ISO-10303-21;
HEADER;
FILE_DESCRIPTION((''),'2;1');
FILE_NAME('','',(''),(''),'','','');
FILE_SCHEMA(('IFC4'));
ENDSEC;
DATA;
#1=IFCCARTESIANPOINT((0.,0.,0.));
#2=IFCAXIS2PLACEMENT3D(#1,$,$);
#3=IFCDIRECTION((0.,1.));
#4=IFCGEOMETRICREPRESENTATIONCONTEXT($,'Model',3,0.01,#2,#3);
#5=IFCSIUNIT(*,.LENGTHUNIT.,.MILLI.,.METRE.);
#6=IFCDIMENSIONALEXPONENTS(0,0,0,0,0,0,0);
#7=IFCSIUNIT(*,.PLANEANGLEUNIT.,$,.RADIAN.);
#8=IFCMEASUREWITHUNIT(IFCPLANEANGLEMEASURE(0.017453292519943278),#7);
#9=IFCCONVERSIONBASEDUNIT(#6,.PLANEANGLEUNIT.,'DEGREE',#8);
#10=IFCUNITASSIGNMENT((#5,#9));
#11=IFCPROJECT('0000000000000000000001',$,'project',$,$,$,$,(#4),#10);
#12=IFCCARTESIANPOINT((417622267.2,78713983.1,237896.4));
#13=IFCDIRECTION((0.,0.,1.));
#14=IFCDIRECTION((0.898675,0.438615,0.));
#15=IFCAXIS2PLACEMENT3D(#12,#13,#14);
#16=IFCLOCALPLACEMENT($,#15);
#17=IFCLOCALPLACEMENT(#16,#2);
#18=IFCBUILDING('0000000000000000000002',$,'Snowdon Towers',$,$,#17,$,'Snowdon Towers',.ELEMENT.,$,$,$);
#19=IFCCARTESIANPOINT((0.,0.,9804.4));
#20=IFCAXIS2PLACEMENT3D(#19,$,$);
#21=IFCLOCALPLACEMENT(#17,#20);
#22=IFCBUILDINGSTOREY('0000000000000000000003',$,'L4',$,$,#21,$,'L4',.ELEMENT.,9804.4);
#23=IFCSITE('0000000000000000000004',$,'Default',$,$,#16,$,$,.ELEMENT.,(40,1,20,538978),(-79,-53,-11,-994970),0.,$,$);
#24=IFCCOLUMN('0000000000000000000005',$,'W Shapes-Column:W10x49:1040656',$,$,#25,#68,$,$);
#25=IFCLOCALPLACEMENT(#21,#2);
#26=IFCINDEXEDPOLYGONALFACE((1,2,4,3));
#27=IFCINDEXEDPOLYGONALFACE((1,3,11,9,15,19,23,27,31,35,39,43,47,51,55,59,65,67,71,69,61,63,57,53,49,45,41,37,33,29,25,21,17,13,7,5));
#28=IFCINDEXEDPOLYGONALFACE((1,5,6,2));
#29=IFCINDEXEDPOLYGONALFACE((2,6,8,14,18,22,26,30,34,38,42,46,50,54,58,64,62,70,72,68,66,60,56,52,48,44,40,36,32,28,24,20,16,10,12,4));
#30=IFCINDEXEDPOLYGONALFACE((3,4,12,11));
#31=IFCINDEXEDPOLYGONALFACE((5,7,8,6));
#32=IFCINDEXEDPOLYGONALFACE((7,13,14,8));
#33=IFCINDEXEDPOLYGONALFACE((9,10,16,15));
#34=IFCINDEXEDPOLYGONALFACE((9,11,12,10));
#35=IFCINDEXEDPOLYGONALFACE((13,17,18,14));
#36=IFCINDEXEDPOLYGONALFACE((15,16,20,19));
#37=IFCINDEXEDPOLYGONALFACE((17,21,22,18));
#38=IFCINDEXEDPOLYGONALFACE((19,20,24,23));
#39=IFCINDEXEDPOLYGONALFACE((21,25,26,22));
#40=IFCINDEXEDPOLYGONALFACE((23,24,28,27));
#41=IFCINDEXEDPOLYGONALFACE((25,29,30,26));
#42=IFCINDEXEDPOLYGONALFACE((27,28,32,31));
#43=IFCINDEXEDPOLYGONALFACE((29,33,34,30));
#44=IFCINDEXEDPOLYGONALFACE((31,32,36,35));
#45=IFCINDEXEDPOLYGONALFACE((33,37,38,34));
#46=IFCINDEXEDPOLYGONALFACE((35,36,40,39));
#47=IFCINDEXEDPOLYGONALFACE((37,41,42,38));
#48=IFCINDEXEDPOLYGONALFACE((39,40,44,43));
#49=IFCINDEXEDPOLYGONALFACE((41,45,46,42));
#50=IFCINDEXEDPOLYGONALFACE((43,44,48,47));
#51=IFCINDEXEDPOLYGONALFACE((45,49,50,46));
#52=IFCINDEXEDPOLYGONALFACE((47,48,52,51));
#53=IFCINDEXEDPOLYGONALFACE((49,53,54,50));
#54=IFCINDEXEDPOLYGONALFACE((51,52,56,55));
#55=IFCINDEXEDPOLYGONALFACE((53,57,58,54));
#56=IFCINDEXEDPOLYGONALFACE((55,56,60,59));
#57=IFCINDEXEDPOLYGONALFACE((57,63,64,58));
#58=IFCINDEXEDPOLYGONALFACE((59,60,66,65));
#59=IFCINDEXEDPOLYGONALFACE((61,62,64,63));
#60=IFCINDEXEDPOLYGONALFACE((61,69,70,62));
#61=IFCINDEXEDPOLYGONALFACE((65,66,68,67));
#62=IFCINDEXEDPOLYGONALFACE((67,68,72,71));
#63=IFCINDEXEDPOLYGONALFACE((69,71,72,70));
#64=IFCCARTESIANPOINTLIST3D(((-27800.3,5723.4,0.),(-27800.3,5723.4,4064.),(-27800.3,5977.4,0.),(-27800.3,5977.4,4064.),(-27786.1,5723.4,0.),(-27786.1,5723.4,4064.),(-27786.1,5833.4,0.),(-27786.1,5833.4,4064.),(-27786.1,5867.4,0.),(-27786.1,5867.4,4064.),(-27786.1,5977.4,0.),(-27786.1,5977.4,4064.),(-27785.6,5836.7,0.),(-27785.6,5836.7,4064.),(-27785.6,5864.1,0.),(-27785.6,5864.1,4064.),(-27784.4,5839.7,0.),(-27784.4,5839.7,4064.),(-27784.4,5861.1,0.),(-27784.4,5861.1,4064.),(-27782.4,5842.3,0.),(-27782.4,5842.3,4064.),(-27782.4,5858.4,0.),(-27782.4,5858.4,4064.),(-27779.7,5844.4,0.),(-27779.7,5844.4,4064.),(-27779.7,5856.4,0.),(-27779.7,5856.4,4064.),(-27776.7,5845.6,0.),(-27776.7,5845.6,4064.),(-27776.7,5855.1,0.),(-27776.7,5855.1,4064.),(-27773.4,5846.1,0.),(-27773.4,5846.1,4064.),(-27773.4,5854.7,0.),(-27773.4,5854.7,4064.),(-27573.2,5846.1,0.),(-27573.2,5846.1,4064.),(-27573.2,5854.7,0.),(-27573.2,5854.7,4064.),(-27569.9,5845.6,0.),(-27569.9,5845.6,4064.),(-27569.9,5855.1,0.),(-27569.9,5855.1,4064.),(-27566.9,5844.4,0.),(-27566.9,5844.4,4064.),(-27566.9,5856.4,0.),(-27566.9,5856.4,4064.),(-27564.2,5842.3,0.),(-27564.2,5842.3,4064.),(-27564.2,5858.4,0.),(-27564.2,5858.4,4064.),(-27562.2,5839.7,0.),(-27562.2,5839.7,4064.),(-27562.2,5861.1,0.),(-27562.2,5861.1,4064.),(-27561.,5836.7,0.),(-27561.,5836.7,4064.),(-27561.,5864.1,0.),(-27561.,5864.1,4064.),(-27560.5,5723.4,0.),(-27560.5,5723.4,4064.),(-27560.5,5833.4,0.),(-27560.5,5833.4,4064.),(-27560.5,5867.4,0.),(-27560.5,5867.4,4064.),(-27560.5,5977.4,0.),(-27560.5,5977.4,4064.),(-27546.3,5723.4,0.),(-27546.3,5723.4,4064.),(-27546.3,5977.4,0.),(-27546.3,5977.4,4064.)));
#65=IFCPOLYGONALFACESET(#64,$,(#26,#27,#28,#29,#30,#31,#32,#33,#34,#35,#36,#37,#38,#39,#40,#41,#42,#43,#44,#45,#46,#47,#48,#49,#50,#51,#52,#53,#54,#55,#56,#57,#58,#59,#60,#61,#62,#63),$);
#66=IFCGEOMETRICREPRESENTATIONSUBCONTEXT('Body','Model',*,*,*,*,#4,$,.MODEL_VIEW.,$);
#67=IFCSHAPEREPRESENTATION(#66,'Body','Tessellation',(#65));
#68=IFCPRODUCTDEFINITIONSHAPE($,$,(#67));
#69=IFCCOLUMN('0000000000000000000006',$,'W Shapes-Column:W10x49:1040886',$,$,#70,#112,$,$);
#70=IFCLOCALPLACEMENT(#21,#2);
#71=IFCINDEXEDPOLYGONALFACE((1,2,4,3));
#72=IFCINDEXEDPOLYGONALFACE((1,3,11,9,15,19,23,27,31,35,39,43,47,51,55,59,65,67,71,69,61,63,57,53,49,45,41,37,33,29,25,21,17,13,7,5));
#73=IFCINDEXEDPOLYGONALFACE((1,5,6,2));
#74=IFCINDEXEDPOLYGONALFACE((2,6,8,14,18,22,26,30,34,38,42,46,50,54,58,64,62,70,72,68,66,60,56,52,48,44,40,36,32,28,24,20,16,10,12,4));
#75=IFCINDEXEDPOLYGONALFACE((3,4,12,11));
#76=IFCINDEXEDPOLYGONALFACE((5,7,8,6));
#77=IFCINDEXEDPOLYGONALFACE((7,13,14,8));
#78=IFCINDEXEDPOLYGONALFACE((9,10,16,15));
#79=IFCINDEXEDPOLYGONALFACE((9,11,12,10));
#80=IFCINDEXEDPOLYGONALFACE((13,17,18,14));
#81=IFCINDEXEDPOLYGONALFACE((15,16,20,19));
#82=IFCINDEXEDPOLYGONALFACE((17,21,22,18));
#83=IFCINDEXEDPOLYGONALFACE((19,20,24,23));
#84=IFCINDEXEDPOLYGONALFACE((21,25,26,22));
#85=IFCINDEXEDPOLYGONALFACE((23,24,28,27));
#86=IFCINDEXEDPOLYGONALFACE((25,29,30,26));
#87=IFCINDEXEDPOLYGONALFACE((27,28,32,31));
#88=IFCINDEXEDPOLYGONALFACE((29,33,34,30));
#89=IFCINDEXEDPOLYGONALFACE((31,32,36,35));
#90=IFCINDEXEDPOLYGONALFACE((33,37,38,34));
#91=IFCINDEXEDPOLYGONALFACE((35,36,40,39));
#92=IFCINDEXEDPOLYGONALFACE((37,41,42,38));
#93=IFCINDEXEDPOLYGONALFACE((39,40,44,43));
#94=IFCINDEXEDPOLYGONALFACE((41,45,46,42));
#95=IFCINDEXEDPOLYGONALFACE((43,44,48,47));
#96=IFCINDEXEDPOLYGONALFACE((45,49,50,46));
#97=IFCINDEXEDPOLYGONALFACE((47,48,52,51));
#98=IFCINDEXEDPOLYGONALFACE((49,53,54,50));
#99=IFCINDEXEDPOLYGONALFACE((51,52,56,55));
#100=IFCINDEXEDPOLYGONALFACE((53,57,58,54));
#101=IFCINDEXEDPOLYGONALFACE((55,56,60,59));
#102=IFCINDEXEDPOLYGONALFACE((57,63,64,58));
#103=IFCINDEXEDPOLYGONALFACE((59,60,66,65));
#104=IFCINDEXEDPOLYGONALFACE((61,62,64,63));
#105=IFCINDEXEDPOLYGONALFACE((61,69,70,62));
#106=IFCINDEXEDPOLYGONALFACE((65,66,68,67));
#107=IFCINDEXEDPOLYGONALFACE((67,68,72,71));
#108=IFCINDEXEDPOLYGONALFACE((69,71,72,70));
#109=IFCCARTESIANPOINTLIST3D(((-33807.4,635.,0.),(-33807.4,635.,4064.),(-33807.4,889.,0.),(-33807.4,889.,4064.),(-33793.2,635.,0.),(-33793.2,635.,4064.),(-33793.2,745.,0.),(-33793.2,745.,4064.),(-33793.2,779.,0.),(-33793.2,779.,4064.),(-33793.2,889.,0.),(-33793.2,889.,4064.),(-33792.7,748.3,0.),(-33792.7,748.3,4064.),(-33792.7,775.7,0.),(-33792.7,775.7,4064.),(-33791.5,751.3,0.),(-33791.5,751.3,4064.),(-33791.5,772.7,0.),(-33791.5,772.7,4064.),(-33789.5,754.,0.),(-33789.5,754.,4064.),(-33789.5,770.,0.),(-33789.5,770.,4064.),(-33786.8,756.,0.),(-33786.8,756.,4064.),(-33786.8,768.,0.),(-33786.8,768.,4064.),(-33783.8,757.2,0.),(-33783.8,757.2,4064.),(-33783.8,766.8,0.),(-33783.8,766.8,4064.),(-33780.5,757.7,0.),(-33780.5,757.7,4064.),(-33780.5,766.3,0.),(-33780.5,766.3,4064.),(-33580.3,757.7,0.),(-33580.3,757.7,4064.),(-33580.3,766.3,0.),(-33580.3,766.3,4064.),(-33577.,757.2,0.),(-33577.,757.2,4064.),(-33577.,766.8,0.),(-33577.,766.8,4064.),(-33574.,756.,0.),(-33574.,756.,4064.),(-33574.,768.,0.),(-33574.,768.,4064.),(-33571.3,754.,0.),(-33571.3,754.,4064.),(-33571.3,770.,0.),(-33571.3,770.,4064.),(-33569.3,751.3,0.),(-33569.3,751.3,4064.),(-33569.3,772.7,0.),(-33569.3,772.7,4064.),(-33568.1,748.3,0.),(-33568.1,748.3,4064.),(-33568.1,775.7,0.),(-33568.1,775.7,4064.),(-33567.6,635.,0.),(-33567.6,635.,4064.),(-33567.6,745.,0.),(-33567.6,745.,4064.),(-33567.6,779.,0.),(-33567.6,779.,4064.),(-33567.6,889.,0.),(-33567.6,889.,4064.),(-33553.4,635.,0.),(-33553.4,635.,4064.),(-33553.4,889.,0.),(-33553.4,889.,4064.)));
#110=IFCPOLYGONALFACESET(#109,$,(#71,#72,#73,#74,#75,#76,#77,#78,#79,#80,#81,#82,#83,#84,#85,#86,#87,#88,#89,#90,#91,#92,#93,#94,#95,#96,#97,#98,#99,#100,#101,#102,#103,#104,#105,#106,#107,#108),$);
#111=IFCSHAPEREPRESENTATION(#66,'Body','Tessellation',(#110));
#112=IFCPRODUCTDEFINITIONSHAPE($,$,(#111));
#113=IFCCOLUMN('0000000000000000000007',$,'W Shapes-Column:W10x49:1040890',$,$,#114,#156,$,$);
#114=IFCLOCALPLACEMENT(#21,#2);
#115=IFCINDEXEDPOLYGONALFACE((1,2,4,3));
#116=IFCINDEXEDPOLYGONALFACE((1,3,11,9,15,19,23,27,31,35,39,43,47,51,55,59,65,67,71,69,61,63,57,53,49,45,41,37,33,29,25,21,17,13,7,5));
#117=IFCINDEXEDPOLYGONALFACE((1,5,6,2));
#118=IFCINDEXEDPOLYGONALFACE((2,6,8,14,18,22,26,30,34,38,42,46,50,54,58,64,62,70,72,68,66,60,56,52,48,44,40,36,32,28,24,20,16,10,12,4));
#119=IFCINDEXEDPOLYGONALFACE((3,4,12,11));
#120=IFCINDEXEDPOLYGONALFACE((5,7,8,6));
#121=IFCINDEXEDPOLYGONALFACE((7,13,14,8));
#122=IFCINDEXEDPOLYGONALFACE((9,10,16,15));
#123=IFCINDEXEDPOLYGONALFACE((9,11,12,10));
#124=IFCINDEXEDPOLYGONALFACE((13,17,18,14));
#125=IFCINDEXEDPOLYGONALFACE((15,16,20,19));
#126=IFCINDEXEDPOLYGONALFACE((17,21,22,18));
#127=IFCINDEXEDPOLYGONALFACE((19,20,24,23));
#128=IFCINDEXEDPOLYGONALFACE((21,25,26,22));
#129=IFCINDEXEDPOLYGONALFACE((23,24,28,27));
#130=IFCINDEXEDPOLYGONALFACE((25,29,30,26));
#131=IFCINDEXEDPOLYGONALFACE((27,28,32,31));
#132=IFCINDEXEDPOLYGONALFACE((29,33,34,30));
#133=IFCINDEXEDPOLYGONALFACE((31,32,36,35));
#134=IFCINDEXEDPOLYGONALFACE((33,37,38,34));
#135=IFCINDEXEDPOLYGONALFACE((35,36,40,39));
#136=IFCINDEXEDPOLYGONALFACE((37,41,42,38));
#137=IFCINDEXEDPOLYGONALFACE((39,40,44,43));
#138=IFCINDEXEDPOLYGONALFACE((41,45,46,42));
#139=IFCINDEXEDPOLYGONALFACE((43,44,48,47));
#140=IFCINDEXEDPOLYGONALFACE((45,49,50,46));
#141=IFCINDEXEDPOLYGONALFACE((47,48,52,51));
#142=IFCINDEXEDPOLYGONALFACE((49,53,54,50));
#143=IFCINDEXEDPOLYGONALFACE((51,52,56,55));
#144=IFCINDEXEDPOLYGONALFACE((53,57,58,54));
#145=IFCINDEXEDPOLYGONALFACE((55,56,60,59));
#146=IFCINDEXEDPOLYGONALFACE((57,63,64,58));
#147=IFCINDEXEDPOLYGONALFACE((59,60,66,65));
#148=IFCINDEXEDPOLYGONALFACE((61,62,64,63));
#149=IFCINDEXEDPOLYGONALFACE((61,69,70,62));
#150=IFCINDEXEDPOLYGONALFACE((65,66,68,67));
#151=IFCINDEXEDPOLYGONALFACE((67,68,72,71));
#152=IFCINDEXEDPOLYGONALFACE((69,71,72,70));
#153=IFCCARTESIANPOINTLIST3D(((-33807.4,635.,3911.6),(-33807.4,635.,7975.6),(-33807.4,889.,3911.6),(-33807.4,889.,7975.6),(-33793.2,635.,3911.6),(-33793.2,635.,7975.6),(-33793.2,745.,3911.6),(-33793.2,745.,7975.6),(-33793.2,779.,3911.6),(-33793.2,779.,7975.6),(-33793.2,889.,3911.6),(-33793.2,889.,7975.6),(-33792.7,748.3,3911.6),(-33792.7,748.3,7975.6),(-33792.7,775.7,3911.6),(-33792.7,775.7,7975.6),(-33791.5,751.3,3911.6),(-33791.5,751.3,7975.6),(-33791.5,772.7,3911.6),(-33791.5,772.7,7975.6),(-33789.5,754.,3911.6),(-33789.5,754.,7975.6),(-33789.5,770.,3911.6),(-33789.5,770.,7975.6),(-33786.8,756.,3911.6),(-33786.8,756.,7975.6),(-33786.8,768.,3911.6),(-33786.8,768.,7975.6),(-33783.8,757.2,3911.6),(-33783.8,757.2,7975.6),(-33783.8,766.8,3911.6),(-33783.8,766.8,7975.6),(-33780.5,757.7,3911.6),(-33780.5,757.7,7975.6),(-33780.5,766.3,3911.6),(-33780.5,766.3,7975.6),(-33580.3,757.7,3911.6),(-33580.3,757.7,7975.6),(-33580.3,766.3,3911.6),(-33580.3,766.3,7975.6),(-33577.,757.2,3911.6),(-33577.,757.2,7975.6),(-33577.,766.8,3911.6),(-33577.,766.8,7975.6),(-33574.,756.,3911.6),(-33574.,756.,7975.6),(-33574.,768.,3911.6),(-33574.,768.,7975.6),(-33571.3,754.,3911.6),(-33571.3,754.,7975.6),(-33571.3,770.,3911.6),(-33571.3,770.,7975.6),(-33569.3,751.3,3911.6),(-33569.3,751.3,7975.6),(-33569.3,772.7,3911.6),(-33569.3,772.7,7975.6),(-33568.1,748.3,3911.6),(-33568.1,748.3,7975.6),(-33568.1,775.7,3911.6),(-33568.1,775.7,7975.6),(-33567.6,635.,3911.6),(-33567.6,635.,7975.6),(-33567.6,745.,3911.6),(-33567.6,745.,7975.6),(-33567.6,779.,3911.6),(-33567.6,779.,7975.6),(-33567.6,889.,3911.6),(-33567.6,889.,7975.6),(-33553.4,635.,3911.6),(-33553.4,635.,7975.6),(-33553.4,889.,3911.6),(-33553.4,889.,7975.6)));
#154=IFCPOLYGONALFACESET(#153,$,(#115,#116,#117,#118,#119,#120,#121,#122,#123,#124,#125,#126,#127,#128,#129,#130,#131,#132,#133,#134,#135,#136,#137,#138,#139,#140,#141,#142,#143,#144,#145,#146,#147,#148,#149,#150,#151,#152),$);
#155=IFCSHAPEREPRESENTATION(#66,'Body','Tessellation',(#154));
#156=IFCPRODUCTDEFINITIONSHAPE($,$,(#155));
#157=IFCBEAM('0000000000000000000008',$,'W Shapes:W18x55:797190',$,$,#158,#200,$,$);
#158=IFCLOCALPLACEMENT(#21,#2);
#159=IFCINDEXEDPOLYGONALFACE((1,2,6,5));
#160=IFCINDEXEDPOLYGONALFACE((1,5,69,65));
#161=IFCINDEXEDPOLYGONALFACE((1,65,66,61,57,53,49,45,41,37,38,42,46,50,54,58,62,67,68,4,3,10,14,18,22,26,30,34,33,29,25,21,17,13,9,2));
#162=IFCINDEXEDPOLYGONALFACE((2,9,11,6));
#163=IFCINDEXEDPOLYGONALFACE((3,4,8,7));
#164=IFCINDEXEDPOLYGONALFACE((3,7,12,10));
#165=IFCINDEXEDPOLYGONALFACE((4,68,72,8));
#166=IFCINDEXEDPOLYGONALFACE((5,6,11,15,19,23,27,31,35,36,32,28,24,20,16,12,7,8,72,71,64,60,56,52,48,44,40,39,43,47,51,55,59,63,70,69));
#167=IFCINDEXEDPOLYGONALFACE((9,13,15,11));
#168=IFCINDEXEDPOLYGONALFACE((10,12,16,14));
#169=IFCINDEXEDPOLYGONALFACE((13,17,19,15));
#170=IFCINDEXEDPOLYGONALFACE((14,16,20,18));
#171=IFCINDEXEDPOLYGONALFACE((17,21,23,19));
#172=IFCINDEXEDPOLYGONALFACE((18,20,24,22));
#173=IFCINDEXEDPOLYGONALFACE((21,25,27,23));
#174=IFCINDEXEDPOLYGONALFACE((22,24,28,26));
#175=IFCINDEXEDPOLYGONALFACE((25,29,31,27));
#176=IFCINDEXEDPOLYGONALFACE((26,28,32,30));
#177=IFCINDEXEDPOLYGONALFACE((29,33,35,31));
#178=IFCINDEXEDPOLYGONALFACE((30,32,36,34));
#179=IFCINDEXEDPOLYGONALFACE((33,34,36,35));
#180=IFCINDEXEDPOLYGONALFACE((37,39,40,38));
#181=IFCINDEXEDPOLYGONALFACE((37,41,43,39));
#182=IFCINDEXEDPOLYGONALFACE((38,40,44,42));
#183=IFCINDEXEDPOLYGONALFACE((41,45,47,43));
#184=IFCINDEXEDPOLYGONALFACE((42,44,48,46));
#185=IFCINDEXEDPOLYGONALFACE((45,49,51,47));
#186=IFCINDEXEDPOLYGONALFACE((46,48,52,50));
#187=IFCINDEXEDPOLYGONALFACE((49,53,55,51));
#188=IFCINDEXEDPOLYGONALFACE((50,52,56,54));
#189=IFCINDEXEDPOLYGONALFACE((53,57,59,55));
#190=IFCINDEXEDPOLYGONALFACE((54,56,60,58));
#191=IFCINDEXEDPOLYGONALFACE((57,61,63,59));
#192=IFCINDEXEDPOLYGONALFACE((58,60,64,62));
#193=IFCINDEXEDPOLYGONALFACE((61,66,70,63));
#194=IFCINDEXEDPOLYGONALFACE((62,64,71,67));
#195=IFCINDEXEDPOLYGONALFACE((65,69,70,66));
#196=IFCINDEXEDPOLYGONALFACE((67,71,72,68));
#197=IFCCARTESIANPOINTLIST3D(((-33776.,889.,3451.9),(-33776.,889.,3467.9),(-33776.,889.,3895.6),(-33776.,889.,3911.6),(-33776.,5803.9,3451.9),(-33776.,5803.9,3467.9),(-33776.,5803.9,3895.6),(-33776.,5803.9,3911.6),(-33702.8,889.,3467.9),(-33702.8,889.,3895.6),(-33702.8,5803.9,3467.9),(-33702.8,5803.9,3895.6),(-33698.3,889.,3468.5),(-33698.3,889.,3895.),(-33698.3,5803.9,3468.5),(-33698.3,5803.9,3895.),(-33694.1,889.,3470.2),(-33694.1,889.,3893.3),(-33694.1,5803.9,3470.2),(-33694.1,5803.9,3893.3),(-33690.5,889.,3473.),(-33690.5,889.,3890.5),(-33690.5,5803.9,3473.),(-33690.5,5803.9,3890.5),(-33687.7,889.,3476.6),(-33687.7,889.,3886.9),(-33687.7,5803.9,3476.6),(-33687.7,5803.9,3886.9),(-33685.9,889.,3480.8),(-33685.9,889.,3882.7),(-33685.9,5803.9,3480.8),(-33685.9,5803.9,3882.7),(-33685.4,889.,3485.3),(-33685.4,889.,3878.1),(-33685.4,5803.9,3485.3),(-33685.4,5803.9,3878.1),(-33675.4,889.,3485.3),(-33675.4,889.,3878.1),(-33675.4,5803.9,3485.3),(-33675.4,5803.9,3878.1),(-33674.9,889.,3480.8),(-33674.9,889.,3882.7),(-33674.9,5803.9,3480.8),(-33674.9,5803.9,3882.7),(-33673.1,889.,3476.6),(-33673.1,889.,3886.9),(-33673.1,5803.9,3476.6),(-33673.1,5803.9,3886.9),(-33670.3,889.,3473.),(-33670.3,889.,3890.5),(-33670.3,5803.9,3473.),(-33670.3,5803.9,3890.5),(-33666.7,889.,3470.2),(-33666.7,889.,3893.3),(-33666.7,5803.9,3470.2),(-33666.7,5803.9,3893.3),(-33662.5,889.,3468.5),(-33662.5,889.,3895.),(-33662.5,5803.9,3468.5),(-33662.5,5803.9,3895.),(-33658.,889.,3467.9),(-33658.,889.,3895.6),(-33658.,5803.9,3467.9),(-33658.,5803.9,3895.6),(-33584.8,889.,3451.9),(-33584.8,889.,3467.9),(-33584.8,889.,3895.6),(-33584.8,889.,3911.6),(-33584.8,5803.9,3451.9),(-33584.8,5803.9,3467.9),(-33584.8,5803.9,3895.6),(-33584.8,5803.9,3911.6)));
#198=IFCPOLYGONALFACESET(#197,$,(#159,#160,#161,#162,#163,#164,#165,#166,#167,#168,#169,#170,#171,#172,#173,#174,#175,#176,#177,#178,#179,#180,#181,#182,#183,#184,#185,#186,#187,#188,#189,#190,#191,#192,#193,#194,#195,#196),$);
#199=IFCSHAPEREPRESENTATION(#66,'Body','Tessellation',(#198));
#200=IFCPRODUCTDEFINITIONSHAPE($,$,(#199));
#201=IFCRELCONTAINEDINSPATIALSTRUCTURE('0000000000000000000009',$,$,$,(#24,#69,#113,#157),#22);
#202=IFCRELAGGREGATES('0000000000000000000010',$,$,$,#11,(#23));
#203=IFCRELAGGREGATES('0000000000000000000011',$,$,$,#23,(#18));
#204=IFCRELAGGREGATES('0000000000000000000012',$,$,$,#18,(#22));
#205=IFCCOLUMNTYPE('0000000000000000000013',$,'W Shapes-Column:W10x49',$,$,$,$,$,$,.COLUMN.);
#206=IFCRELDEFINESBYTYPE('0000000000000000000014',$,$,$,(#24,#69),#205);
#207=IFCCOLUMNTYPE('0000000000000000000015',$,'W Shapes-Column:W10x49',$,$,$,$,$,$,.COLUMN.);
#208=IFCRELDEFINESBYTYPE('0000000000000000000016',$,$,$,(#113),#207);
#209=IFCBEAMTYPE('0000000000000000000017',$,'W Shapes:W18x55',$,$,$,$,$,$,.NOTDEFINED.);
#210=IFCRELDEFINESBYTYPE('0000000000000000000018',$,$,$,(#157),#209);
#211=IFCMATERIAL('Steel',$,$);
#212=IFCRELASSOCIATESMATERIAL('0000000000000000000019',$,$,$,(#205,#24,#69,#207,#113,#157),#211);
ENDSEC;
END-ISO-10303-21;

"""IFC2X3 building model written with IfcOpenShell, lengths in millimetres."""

from ifc_helpers import new_model, entity, si_unit, converted_unit, direction, frame, frame_2d, origin, place, context, subcontext, project, spatial, i_section, extrude, source, transform, mapped, material, type_object, type_shapes, element, save


model = new_model("IFC2X3")

# Units and contexts
model_context = context("Model", 3, precision=0.01, world=origin(), true_north=direction((0.0, 1.0)))
body_context = subcontext(model_context, "Body", "Model", "MODEL_VIEW")
ifc_project = project(units=[si_unit("LENGTHUNIT", "METRE", prefix="MILLI"), converted_unit("PLANEANGLEUNIT", "DEGREE", entity("IfcPlaneAngleMeasure", 0.017453292519943278), si_unit("PLANEANGLEUNIT", "RADIAN"), dimensions=[0, 0, 0, 0, 0, 0, 0])], contexts=[model_context])

# Site, building, storey
site_placement = place(None, frame((417622267.2, 78713983.1, 237896.4), z_axis=(0.0, 0.0, 1.0), x_axis=(0.898675, 0.438615, 0.0)))
site = spatial("IfcSite", under=ifc_project, at=site_placement, Name="Default", CompositionType="ELEMENT", RefLatitude=(40, 1, 20, 538978), RefLongitude=(-79, -53, -11, -994970), RefElevation=0.0)
building_placement = place(site_placement, origin())
building = spatial("IfcBuilding", under=site, at=building_placement, Name="Snowdon Towers", LongName="Snowdon Towers", CompositionType="ELEMENT")
storey_placement = place(building_placement, frame((0.0, 0.0, 9804.4)))
storey = spatial("IfcBuildingStorey", under=building, at=storey_placement, Name="L4", LongName="L4", CompositionType="ELEMENT", Elevation=9804.4)

# Columns
ifc_material_1 = material(Name="Steel")
column_type_1 = type_object("IfcColumnType", Name="W Shapes-Column:W10x49", PredefinedType="COLUMN", material=ifc_material_1)
shared_shape_1 = source(origin(), body_context, "Body", "SweptSolid", [
    extrude(i_section(OverallWidth=254.0, OverallDepth=254.0, WebThickness=8.6, FlangeThickness=14.2, FilletRadius=12.7, at=frame_2d((0.0, 0.0), x_axis=(1.0, 0.0))), frame((0.0, 0.0, 9804.4), z_axis=(0.0, 0.0, 1.0), x_axis=(-1.0, 0.0, 0.0)), (0.0, 0.0, 1.0), 4064.0),
])
type_shapes(column_type_1, [shared_shape_1])
for number, where, z_axis, x_axis, name in (
    (1, (-27673.3, 5850.4, -9804.4), (0.0, 0.0, 1.0), (0.0, 1.0, 0.0), "W Shapes-Column:W10x49:1040656"),
    (2, (-33680.4, 762.0, -9804.4), (0.0, 0.0, 1.0), (0.0, 1.0, 0.0), "W Shapes-Column:W10x49:1040886"),
):
    element("IfcColumn", number, at=place(storey_placement, frame(where, z_axis=z_axis, x_axis=x_axis)), inside=storey, type_object=column_type_1, material=ifc_material_1, Name=name, context=body_context, shape_type="MappedRepresentation", body=[
        mapped(shared_shape_1, transform((0.0, 0.0, 0.0), scale=1.0)),
    ])
column_type_2 = type_object("IfcColumnType", Name="W Shapes-Column:W10x49", PredefinedType="COLUMN", material=ifc_material_1)
shared_shape_2 = source(origin(), body_context, "Body", "SweptSolid", [
    extrude(i_section(OverallWidth=254.0, OverallDepth=254.0, WebThickness=8.6, FlangeThickness=14.2, FilletRadius=12.7, at=frame_2d((0.0, 0.0), x_axis=(1.0, 0.0))), frame((0.0, 0.0, 13716.0), z_axis=(0.0, 0.0, 1.0), x_axis=(-1.0, 0.0, 0.0)), (0.0, 0.0, 1.0), 4064.0),
])
type_shapes(column_type_2, [shared_shape_2])
column_placement = place(storey_placement, frame((-33680.4, 762.0, -9804.4), z_axis=(0.0, 0.0, 1.0), x_axis=(0.0, 1.0, 0.0)))
element("IfcColumn", 3, at=column_placement, inside=storey, type_object=column_type_2, material=ifc_material_1, Name="W Shapes-Column:W10x49:1040890", context=body_context, shape_type="MappedRepresentation", body=[
    mapped(shared_shape_2, transform((0.0, 0.0, 0.0), scale=1.0)),
])

# Beam
beam_type_1 = type_object("IfcBeamType", Name="W Shapes:W18x55", PredefinedType="NOTDEFINED")
beam_1_placement = place(storey_placement, frame((-33680.4, 762.0, 3911.6), z_axis=(0.0, 0.0, 1.0), x_axis=(0.0, 1.0, 0.0)))
element("IfcBeam", 4, at=beam_1_placement, inside=storey, type_object=beam_type_1, material=ifc_material_1, Name="W Shapes:W18x55:797190", context=body_context, shape_type="SweptSolid", body=[
    extrude(i_section(OverallWidth=191.3, OverallDepth=459.7, WebThickness=9.9, FlangeThickness=16.0, FilletRadius=17.5, at=frame_2d((0.0, 0.0), x_axis=(0.0, 1.0))), frame((127.0, 0.0, -229.9), z_axis=(1.0, 0.0, 0.0), x_axis=(0.0, 0.0, -1.0)), (0.0, 0.0, 1.0), 4914.9),
])

save(model, "model.ifc")
